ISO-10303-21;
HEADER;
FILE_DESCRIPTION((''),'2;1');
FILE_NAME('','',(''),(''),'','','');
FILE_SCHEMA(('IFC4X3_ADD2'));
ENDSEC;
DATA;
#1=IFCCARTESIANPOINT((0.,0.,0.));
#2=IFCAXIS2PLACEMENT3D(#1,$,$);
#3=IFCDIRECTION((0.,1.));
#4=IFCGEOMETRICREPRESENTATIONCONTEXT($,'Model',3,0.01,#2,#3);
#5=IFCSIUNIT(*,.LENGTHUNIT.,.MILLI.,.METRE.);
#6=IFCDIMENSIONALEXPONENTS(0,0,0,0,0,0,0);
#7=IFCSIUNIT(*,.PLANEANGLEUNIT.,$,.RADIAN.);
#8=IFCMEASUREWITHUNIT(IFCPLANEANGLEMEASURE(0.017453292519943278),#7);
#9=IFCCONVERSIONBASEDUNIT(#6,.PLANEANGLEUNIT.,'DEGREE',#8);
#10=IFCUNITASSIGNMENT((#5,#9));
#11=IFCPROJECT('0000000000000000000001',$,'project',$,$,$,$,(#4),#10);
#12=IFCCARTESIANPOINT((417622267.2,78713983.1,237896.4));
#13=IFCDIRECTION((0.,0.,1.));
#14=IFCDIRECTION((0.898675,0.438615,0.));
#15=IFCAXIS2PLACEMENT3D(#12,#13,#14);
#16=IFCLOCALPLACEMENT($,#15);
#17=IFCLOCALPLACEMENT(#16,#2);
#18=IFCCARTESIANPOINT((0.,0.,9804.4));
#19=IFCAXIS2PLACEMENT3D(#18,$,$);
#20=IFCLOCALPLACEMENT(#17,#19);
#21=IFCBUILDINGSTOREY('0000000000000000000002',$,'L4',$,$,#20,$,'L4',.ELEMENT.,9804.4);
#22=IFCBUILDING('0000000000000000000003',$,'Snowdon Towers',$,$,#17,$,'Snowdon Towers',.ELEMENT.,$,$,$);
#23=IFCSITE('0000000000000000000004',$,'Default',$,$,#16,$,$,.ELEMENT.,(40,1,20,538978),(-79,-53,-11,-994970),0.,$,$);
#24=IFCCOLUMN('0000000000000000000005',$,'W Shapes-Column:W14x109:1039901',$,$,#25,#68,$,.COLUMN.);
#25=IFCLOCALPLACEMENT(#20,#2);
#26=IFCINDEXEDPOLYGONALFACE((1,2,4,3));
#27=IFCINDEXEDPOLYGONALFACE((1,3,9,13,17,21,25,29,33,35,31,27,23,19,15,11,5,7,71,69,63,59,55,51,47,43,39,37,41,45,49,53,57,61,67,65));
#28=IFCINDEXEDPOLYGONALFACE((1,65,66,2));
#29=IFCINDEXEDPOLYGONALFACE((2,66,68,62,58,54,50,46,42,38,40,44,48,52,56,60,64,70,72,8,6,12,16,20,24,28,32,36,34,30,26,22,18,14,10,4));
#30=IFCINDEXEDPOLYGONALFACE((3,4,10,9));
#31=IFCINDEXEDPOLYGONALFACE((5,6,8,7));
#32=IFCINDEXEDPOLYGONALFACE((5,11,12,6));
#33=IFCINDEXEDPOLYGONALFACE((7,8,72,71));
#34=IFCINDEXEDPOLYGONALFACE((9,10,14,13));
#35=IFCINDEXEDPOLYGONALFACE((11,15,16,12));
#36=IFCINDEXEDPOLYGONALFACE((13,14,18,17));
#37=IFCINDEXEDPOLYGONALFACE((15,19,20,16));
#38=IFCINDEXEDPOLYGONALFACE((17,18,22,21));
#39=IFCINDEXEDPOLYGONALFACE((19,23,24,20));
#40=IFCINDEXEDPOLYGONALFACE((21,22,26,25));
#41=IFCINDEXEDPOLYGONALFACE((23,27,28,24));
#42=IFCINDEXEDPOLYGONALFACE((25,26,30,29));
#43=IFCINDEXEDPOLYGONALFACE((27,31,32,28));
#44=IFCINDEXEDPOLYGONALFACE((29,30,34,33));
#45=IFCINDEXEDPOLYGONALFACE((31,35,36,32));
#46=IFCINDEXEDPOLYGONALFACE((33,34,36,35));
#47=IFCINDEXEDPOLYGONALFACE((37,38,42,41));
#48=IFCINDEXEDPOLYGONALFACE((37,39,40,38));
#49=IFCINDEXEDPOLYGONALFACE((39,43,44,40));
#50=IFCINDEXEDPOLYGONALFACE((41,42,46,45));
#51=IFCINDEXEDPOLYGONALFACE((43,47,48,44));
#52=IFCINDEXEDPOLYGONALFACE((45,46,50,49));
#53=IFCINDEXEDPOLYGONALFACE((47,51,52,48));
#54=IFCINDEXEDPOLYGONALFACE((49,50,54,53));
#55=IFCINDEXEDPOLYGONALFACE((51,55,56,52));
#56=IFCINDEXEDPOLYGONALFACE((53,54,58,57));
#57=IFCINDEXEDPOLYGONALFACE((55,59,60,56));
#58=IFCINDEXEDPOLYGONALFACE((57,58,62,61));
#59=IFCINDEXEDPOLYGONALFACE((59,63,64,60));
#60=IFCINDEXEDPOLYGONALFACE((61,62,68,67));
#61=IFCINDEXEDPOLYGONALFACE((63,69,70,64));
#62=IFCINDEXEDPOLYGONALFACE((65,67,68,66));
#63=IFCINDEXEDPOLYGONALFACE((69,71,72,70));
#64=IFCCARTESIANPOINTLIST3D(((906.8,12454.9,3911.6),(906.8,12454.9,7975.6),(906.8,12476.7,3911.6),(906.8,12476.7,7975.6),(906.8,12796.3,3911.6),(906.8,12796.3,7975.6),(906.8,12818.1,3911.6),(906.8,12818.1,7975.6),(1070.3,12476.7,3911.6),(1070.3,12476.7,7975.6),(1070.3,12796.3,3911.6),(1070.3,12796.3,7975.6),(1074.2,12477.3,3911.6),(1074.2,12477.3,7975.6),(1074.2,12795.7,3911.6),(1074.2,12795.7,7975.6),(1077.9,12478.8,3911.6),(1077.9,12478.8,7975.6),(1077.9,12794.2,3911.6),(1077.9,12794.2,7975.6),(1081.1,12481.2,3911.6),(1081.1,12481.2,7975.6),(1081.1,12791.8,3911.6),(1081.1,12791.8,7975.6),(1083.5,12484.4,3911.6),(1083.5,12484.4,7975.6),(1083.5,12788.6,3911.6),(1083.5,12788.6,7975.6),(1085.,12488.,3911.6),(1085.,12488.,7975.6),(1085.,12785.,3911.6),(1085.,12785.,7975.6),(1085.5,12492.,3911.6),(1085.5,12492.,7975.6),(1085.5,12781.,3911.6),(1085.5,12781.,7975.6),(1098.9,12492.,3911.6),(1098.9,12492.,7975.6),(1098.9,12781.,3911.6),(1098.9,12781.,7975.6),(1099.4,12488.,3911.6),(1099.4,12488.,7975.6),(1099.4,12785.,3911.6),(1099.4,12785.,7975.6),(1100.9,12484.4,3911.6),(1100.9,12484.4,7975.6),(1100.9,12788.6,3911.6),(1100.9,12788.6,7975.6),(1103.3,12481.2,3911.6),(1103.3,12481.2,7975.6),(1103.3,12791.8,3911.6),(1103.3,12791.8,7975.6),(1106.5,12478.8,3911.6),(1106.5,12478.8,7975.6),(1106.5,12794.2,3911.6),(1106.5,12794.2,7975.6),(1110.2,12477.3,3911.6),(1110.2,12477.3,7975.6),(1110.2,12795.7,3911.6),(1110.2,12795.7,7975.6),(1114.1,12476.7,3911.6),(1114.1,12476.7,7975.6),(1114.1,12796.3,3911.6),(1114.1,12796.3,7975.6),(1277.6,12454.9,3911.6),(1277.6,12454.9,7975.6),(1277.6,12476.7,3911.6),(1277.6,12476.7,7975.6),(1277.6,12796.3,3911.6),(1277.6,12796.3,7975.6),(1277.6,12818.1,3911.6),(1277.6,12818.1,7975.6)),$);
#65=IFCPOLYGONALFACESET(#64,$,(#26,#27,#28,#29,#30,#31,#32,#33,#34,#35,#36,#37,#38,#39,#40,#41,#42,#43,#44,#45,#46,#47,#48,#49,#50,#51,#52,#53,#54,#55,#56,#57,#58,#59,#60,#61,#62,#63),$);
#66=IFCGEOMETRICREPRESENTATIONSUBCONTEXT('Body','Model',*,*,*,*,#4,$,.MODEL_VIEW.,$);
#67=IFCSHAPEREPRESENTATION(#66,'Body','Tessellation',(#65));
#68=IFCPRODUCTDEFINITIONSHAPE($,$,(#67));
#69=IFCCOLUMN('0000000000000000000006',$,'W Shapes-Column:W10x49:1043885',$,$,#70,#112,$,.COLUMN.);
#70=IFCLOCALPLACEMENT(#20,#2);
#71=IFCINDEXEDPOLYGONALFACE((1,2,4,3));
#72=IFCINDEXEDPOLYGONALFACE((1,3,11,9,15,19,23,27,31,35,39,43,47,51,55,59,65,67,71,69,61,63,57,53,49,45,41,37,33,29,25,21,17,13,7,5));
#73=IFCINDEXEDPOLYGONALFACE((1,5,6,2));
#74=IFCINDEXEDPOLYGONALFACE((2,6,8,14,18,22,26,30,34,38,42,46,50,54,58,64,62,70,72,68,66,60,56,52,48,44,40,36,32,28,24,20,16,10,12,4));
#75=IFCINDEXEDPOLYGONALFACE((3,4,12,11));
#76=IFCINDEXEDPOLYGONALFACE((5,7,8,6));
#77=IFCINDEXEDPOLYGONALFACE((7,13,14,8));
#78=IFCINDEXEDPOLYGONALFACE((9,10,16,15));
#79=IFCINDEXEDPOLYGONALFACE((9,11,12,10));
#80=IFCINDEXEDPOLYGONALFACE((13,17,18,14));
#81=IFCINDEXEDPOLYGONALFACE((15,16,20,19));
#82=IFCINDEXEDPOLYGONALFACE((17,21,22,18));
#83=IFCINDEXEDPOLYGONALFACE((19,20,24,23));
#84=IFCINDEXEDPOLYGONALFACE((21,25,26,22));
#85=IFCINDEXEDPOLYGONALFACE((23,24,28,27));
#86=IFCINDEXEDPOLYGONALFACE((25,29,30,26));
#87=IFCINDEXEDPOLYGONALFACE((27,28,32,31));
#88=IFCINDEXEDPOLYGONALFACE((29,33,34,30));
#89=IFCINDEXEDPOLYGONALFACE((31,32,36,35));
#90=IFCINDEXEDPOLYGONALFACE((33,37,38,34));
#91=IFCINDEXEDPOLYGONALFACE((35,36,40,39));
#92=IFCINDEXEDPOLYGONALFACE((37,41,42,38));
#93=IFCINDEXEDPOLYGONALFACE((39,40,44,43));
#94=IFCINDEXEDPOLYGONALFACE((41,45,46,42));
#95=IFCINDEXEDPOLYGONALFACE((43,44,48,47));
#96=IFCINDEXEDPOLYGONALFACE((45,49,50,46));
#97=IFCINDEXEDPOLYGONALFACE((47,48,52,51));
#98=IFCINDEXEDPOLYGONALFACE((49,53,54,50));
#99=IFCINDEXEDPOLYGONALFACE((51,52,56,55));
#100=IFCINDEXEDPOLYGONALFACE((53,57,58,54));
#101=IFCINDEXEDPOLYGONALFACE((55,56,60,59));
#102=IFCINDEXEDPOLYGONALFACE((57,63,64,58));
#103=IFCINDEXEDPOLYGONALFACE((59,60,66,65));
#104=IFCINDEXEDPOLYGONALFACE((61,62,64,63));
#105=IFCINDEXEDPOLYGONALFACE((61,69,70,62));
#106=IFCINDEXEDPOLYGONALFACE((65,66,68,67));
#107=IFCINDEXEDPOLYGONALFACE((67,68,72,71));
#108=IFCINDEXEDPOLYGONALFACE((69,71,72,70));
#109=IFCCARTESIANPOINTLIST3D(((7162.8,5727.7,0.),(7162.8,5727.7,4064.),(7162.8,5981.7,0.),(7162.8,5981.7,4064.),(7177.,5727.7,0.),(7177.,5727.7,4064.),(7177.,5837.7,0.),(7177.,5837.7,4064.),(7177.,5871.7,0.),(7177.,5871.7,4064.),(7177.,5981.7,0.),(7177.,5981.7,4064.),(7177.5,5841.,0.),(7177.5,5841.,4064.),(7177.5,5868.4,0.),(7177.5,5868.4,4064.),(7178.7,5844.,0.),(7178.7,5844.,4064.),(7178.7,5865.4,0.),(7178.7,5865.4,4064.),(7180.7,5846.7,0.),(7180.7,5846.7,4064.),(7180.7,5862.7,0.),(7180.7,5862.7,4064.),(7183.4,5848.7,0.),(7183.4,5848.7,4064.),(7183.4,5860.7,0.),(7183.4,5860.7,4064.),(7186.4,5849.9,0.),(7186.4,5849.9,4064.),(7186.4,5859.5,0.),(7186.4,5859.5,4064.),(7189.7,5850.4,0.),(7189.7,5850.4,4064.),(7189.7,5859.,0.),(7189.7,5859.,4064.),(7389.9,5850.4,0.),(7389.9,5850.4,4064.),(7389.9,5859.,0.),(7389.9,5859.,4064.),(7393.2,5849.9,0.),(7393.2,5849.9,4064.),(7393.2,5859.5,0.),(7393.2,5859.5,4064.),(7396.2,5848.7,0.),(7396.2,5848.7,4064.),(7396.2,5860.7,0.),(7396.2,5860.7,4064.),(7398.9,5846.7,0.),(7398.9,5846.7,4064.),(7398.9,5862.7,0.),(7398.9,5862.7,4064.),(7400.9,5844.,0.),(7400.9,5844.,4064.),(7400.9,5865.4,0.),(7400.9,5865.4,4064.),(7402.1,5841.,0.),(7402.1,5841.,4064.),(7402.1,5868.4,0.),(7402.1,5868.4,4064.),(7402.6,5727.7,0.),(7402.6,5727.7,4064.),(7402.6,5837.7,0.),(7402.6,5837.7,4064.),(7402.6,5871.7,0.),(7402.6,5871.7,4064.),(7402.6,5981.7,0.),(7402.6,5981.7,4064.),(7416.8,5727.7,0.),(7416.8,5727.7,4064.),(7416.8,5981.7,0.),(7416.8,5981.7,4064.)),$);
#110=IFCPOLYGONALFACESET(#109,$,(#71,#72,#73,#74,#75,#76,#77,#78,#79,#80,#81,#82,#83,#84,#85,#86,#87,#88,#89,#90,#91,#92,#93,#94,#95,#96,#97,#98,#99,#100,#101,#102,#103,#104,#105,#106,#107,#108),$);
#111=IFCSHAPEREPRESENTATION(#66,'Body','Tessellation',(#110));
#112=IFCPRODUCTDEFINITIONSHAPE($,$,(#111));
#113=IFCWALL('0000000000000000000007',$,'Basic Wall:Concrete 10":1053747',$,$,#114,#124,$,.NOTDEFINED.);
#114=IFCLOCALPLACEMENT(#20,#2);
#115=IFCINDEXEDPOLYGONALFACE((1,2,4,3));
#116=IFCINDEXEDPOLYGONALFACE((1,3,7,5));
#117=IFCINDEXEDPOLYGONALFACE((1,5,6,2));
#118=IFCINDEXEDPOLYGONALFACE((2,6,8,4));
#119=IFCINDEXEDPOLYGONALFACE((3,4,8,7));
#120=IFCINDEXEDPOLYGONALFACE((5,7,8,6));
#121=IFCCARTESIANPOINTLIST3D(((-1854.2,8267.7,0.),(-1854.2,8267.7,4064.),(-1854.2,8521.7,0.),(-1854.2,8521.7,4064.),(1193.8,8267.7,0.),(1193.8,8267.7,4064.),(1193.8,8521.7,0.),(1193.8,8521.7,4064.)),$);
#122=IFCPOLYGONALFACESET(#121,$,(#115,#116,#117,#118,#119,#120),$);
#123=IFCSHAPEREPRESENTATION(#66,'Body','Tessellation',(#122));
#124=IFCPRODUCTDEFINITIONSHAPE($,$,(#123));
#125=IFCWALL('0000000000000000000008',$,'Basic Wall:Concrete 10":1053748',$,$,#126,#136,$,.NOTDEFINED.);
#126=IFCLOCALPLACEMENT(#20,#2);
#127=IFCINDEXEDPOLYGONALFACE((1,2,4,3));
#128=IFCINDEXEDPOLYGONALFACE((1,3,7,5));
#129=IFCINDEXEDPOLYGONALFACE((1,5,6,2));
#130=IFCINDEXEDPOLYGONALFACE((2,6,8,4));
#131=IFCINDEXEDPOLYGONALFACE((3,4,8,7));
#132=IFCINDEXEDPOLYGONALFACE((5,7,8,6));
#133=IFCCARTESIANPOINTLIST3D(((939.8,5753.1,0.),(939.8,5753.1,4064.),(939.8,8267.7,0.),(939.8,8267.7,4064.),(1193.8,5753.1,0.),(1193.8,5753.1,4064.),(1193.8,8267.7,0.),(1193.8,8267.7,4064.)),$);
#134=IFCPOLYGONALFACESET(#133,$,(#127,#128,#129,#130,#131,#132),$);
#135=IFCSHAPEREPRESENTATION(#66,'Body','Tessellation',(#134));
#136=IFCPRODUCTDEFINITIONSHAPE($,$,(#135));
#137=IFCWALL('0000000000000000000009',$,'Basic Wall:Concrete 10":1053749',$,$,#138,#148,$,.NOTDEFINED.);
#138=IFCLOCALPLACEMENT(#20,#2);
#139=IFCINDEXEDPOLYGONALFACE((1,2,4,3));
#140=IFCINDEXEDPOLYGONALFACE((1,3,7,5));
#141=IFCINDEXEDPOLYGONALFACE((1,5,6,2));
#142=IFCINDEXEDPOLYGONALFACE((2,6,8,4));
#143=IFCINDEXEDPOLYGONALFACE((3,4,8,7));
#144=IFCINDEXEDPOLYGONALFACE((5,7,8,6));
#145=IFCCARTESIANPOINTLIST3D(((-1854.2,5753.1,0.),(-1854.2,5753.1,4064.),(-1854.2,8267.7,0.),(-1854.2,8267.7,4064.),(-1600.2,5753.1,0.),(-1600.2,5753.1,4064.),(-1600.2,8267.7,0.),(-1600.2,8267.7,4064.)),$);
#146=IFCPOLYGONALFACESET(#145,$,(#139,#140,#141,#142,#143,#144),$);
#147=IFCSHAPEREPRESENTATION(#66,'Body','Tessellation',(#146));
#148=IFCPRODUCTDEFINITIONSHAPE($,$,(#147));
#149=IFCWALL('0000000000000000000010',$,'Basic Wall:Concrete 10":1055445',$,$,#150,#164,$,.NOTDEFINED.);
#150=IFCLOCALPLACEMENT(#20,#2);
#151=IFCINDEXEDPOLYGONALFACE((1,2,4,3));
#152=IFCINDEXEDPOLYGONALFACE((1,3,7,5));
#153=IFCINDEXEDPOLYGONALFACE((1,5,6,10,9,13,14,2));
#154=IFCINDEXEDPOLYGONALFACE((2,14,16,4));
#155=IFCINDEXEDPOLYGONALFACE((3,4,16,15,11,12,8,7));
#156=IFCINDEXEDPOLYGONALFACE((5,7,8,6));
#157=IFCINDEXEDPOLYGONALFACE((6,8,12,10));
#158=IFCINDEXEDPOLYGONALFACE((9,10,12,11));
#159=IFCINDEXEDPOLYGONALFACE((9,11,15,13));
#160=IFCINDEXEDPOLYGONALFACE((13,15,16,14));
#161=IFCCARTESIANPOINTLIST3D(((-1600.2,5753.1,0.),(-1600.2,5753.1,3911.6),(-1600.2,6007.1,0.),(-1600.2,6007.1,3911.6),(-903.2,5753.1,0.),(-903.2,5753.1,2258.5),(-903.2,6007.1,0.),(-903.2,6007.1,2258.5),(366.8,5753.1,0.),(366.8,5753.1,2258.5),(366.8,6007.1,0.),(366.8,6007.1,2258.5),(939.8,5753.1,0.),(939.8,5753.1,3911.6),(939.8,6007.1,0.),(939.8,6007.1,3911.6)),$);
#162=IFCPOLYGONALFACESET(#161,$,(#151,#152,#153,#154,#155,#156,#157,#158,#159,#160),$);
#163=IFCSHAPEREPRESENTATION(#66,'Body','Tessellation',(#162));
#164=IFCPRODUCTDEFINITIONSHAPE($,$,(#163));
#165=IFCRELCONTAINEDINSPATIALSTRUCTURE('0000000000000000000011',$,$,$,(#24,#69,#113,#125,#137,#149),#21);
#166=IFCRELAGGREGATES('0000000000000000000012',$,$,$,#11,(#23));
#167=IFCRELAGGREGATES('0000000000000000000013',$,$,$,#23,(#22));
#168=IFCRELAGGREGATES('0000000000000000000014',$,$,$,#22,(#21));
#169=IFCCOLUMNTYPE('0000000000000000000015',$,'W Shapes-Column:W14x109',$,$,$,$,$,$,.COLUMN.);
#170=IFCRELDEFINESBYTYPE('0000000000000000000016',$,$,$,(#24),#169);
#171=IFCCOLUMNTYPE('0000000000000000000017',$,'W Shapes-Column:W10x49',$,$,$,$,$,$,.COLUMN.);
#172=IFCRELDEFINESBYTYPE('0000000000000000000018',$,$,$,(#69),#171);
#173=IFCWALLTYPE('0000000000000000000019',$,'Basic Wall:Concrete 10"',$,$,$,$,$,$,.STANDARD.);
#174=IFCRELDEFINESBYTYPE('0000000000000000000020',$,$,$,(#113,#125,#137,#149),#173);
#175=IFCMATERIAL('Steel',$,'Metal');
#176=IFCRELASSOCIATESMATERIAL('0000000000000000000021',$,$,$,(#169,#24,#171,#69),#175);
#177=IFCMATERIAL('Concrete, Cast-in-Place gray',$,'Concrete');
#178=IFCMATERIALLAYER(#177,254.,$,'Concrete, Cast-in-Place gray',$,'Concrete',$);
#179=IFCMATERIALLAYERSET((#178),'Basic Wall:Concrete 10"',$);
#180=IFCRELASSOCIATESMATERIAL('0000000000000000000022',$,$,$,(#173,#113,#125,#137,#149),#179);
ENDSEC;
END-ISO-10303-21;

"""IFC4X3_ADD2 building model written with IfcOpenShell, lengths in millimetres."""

from ifc_helpers import new_model, entity, si_unit, converted_unit, direction, frame, frame_2d, origin, place, context, subcontext, project, spatial, rectangle, i_section, extrude, source, transform, mapped, material, layer, layer_set, material_profile, profile_set, profile_usage, type_object, type_shapes, element, save


model = new_model("IFC4X3_ADD2")

# Units and contexts
model_context = context("Model", 3, precision=0.01, world=origin(), true_north=direction((0.0, 1.0)))
body_context = subcontext(model_context, "Body", "Model", "MODEL_VIEW")
ifc_project = project(units=[si_unit("LENGTHUNIT", "METRE", prefix="MILLI"), converted_unit("PLANEANGLEUNIT", "DEGREE", entity("IfcPlaneAngleMeasure", 0.017453292519943278), si_unit("PLANEANGLEUNIT", "RADIAN"), dimensions=[0, 0, 0, 0, 0, 0, 0])], contexts=[model_context])

# Site, building, storey
site_placement = place(None, frame((417622267.2, 78713983.1, 237896.4), z_axis=(0.0, 0.0, 1.0), x_axis=(0.898675, 0.438615, 0.0)))
site = spatial("IfcSite", under=ifc_project, at=site_placement, Name="Default", CompositionType="ELEMENT", RefLatitude=(40, 1, 20, 538978), RefLongitude=(-79, -53, -11, -994970), RefElevation=0.0)
building_placement = place(site_placement, origin())
building = spatial("IfcBuilding", under=site, at=building_placement, Name="Snowdon Towers", LongName="Snowdon Towers", CompositionType="ELEMENT")
storey_placement = place(building_placement, frame((0.0, 0.0, 9804.4)))
storey = spatial("IfcBuildingStorey", under=building, at=storey_placement, Name="L4", LongName="L4", CompositionType="ELEMENT", Elevation=9804.4)

# Columns
ifc_material_1 = material(Name="Steel", Category="Metal")
ifc_material_profile_1 = material_profile(ifc_material_1, i_section(OverallWidth=370.8, OverallDepth=363.2, WebThickness=13.3, FlangeThickness=21.8, FilletRadius=15.2, at=frame_2d((0.0, 0.0), x_axis=(1.0, 0.0))), Name="W14x109")
ifc_profile_set_1 = profile_set([ifc_material_profile_1], Name="W14x109")
ifc_profile_usage_1 = profile_usage(ifc_profile_set_1)
column_type_1 = type_object("IfcColumnType", Name="W Shapes-Column:W14x109", PredefinedType="COLUMN", material=ifc_profile_set_1)
shared_shape_1 = source(origin(), body_context, "Body", "SweptSolid", [
    extrude(i_section(OverallWidth=370.8, OverallDepth=363.2, WebThickness=13.3, FlangeThickness=21.8, FilletRadius=15.2, at=frame_2d((0.0, 0.0), x_axis=(1.0, 0.0))), frame((0.0, 0.0, 13716.0), z_axis=(0.0, 0.0, 1.0), x_axis=(-1.0, 0.0, 0.0)), (0.0, 0.0, 1.0), 4064.0),
])
type_shapes(column_type_1, [shared_shape_1])
column_1_placement = place(storey_placement, frame((1092.2, 12636.5, -9804.4), z_axis=(0.0, 0.0, 1.0), x_axis=(-1.0, 0.0, 0.0)))
element("IfcColumn", 1, at=column_1_placement, inside=storey, type_object=column_type_1, material=ifc_profile_usage_1, Name="W Shapes-Column:W14x109:1039901", PredefinedType="COLUMN", context=body_context, shape_type="MappedRepresentation", body=[
    mapped(shared_shape_1, transform((0.0, 0.0, 0.0), scale=1.0)),
])
ifc_material_profile_2 = material_profile(ifc_material_1, i_section(OverallWidth=254.0, OverallDepth=254.0, WebThickness=8.6, FlangeThickness=14.2, FilletRadius=12.7, at=frame_2d((0.0, 0.0), x_axis=(1.0, 0.0))), Name="W10x49")
ifc_profile_set_2 = profile_set([ifc_material_profile_2], Name="W10x49")
ifc_profile_usage_2 = profile_usage(ifc_profile_set_2)
column_type_2 = type_object("IfcColumnType", Name="W Shapes-Column:W10x49", PredefinedType="COLUMN", material=ifc_profile_set_2)
shared_shape_2 = source(origin(), body_context, "Body", "SweptSolid", [
    extrude(i_section(OverallWidth=254.0, OverallDepth=254.0, WebThickness=8.6, FlangeThickness=14.2, FilletRadius=12.7, at=frame_2d((0.0, 0.0), x_axis=(1.0, 0.0))), frame((0.0, 0.0, 9804.4), z_axis=(0.0, 0.0, 1.0), x_axis=(-1.0, 0.0, 0.0)), (0.0, 0.0, 1.0), 4064.0),
])
type_shapes(column_type_2, [shared_shape_2])
column_2_placement = place(storey_placement, frame((7289.8, 5854.7, -9804.4), z_axis=(0.0, 0.0, 1.0), x_axis=(0.0, 1.0, 0.0)))
element("IfcColumn", 2, at=column_2_placement, inside=storey, type_object=column_type_2, material=ifc_profile_usage_2, Name="W Shapes-Column:W10x49:1043885", PredefinedType="COLUMN", context=body_context, shape_type="MappedRepresentation", body=[
    mapped(shared_shape_2, transform((0.0, 0.0, 0.0), scale=1.0)),
])

# Walls
ifc_material_2 = material(Name="Concrete, Cast-in-Place gray", Category="Concrete")
ifc_layer = layer(ifc_material_2, 254.0, Name="Concrete, Cast-in-Place gray", Category="Concrete")
ifc_layer_set = layer_set([ifc_layer], Name="Basic Wall:Concrete 10\"")
wall_type = type_object("IfcWallType", Name="Basic Wall:Concrete 10\"", PredefinedType="STANDARD", material=ifc_layer_set)
wall_1_placement = place(storey_placement, frame((-1854.2, 8394.7, 0.0)))
element("IfcWall", 3, at=wall_1_placement, inside=storey, type_object=wall_type, material=ifc_layer_set, Name="Basic Wall:Concrete 10\":1053747", PredefinedType="NOTDEFINED", context=body_context, shape_type="SweptSolid", body=[
    extrude(rectangle(XDim=3048.0, YDim=254.0, at=frame_2d((1524.0, 0.0), x_axis=(-1.0, 0.0))), origin(), (0.0, 0.0, 1.0), 4064.0),
])
wall_2_placement = place(storey_placement, frame((1066.8, 8267.7, 0.0), z_axis=(0.0, 0.0, 1.0), x_axis=(0.0, -1.0, 0.0)))
element("IfcWall", 4, at=wall_2_placement, inside=storey, type_object=wall_type, material=ifc_layer_set, Name="Basic Wall:Concrete 10\":1053748", PredefinedType="NOTDEFINED", context=body_context, shape_type="SweptSolid", body=[
    extrude(rectangle(XDim=2514.6, YDim=254.0, at=frame_2d((1257.3, 0.0), x_axis=(-1.0, 0.0))), origin(), (0.0, 0.0, 1.0), 4064.0),
])
wall_3_placement = place(storey_placement, frame((-1727.2, 5753.1, 0.0), z_axis=(0.0, 0.0, 1.0), x_axis=(0.0, 1.0, 0.0)))
element("IfcWall", 5, at=wall_3_placement, inside=storey, type_object=wall_type, material=ifc_layer_set, Name="Basic Wall:Concrete 10\":1053749", PredefinedType="NOTDEFINED", context=body_context, shape_type="SweptSolid", body=[
    extrude(rectangle(XDim=2514.6, YDim=254.0, at=frame_2d((1257.3, 0.0), x_axis=(-1.0, 0.0))), origin(), (0.0, 0.0, 1.0), 4064.0),
])

# Wall, opening
wall_4_placement = place(storey_placement, frame((939.8, 5880.1, 0.0), z_axis=(0.0, 0.0, 1.0), x_axis=(-1.0, 0.0, 0.0)))
wall_4 = element("IfcWall", 6, at=wall_4_placement, inside=storey, type_object=wall_type, material=ifc_layer_set, Name="Basic Wall:Concrete 10\":1055445", PredefinedType="NOTDEFINED", context=body_context, shape_type="SweptSolid", body=[
    extrude(rectangle(XDim=2540.0, YDim=254.0, at=frame_2d((1270.0, 0.0), x_axis=(-1.0, 0.0))), origin(), (0.0, 0.0, 1.0), 3911.6),
])
opening_placement = place(wall_4_placement, origin())
element("IfcOpeningElement", 7, at=opening_placement, cuts=wall_4, PredefinedType="OPENING", context=body_context, shape_type="SweptSolid", body=[
    extrude(rectangle(XDim=2258.5, YDim=1270.0, at=frame_2d((0.0, 0.0), x_axis=(0.0, 1.0))), frame((1208.0, 127.0, 1129.2), z_axis=(0.0, -1.0, 0.0), x_axis=(1.0, 0.0, 0.0)), (0.0, 0.0, 1.0), 254.0),
])

save(model, "model.ifc")
